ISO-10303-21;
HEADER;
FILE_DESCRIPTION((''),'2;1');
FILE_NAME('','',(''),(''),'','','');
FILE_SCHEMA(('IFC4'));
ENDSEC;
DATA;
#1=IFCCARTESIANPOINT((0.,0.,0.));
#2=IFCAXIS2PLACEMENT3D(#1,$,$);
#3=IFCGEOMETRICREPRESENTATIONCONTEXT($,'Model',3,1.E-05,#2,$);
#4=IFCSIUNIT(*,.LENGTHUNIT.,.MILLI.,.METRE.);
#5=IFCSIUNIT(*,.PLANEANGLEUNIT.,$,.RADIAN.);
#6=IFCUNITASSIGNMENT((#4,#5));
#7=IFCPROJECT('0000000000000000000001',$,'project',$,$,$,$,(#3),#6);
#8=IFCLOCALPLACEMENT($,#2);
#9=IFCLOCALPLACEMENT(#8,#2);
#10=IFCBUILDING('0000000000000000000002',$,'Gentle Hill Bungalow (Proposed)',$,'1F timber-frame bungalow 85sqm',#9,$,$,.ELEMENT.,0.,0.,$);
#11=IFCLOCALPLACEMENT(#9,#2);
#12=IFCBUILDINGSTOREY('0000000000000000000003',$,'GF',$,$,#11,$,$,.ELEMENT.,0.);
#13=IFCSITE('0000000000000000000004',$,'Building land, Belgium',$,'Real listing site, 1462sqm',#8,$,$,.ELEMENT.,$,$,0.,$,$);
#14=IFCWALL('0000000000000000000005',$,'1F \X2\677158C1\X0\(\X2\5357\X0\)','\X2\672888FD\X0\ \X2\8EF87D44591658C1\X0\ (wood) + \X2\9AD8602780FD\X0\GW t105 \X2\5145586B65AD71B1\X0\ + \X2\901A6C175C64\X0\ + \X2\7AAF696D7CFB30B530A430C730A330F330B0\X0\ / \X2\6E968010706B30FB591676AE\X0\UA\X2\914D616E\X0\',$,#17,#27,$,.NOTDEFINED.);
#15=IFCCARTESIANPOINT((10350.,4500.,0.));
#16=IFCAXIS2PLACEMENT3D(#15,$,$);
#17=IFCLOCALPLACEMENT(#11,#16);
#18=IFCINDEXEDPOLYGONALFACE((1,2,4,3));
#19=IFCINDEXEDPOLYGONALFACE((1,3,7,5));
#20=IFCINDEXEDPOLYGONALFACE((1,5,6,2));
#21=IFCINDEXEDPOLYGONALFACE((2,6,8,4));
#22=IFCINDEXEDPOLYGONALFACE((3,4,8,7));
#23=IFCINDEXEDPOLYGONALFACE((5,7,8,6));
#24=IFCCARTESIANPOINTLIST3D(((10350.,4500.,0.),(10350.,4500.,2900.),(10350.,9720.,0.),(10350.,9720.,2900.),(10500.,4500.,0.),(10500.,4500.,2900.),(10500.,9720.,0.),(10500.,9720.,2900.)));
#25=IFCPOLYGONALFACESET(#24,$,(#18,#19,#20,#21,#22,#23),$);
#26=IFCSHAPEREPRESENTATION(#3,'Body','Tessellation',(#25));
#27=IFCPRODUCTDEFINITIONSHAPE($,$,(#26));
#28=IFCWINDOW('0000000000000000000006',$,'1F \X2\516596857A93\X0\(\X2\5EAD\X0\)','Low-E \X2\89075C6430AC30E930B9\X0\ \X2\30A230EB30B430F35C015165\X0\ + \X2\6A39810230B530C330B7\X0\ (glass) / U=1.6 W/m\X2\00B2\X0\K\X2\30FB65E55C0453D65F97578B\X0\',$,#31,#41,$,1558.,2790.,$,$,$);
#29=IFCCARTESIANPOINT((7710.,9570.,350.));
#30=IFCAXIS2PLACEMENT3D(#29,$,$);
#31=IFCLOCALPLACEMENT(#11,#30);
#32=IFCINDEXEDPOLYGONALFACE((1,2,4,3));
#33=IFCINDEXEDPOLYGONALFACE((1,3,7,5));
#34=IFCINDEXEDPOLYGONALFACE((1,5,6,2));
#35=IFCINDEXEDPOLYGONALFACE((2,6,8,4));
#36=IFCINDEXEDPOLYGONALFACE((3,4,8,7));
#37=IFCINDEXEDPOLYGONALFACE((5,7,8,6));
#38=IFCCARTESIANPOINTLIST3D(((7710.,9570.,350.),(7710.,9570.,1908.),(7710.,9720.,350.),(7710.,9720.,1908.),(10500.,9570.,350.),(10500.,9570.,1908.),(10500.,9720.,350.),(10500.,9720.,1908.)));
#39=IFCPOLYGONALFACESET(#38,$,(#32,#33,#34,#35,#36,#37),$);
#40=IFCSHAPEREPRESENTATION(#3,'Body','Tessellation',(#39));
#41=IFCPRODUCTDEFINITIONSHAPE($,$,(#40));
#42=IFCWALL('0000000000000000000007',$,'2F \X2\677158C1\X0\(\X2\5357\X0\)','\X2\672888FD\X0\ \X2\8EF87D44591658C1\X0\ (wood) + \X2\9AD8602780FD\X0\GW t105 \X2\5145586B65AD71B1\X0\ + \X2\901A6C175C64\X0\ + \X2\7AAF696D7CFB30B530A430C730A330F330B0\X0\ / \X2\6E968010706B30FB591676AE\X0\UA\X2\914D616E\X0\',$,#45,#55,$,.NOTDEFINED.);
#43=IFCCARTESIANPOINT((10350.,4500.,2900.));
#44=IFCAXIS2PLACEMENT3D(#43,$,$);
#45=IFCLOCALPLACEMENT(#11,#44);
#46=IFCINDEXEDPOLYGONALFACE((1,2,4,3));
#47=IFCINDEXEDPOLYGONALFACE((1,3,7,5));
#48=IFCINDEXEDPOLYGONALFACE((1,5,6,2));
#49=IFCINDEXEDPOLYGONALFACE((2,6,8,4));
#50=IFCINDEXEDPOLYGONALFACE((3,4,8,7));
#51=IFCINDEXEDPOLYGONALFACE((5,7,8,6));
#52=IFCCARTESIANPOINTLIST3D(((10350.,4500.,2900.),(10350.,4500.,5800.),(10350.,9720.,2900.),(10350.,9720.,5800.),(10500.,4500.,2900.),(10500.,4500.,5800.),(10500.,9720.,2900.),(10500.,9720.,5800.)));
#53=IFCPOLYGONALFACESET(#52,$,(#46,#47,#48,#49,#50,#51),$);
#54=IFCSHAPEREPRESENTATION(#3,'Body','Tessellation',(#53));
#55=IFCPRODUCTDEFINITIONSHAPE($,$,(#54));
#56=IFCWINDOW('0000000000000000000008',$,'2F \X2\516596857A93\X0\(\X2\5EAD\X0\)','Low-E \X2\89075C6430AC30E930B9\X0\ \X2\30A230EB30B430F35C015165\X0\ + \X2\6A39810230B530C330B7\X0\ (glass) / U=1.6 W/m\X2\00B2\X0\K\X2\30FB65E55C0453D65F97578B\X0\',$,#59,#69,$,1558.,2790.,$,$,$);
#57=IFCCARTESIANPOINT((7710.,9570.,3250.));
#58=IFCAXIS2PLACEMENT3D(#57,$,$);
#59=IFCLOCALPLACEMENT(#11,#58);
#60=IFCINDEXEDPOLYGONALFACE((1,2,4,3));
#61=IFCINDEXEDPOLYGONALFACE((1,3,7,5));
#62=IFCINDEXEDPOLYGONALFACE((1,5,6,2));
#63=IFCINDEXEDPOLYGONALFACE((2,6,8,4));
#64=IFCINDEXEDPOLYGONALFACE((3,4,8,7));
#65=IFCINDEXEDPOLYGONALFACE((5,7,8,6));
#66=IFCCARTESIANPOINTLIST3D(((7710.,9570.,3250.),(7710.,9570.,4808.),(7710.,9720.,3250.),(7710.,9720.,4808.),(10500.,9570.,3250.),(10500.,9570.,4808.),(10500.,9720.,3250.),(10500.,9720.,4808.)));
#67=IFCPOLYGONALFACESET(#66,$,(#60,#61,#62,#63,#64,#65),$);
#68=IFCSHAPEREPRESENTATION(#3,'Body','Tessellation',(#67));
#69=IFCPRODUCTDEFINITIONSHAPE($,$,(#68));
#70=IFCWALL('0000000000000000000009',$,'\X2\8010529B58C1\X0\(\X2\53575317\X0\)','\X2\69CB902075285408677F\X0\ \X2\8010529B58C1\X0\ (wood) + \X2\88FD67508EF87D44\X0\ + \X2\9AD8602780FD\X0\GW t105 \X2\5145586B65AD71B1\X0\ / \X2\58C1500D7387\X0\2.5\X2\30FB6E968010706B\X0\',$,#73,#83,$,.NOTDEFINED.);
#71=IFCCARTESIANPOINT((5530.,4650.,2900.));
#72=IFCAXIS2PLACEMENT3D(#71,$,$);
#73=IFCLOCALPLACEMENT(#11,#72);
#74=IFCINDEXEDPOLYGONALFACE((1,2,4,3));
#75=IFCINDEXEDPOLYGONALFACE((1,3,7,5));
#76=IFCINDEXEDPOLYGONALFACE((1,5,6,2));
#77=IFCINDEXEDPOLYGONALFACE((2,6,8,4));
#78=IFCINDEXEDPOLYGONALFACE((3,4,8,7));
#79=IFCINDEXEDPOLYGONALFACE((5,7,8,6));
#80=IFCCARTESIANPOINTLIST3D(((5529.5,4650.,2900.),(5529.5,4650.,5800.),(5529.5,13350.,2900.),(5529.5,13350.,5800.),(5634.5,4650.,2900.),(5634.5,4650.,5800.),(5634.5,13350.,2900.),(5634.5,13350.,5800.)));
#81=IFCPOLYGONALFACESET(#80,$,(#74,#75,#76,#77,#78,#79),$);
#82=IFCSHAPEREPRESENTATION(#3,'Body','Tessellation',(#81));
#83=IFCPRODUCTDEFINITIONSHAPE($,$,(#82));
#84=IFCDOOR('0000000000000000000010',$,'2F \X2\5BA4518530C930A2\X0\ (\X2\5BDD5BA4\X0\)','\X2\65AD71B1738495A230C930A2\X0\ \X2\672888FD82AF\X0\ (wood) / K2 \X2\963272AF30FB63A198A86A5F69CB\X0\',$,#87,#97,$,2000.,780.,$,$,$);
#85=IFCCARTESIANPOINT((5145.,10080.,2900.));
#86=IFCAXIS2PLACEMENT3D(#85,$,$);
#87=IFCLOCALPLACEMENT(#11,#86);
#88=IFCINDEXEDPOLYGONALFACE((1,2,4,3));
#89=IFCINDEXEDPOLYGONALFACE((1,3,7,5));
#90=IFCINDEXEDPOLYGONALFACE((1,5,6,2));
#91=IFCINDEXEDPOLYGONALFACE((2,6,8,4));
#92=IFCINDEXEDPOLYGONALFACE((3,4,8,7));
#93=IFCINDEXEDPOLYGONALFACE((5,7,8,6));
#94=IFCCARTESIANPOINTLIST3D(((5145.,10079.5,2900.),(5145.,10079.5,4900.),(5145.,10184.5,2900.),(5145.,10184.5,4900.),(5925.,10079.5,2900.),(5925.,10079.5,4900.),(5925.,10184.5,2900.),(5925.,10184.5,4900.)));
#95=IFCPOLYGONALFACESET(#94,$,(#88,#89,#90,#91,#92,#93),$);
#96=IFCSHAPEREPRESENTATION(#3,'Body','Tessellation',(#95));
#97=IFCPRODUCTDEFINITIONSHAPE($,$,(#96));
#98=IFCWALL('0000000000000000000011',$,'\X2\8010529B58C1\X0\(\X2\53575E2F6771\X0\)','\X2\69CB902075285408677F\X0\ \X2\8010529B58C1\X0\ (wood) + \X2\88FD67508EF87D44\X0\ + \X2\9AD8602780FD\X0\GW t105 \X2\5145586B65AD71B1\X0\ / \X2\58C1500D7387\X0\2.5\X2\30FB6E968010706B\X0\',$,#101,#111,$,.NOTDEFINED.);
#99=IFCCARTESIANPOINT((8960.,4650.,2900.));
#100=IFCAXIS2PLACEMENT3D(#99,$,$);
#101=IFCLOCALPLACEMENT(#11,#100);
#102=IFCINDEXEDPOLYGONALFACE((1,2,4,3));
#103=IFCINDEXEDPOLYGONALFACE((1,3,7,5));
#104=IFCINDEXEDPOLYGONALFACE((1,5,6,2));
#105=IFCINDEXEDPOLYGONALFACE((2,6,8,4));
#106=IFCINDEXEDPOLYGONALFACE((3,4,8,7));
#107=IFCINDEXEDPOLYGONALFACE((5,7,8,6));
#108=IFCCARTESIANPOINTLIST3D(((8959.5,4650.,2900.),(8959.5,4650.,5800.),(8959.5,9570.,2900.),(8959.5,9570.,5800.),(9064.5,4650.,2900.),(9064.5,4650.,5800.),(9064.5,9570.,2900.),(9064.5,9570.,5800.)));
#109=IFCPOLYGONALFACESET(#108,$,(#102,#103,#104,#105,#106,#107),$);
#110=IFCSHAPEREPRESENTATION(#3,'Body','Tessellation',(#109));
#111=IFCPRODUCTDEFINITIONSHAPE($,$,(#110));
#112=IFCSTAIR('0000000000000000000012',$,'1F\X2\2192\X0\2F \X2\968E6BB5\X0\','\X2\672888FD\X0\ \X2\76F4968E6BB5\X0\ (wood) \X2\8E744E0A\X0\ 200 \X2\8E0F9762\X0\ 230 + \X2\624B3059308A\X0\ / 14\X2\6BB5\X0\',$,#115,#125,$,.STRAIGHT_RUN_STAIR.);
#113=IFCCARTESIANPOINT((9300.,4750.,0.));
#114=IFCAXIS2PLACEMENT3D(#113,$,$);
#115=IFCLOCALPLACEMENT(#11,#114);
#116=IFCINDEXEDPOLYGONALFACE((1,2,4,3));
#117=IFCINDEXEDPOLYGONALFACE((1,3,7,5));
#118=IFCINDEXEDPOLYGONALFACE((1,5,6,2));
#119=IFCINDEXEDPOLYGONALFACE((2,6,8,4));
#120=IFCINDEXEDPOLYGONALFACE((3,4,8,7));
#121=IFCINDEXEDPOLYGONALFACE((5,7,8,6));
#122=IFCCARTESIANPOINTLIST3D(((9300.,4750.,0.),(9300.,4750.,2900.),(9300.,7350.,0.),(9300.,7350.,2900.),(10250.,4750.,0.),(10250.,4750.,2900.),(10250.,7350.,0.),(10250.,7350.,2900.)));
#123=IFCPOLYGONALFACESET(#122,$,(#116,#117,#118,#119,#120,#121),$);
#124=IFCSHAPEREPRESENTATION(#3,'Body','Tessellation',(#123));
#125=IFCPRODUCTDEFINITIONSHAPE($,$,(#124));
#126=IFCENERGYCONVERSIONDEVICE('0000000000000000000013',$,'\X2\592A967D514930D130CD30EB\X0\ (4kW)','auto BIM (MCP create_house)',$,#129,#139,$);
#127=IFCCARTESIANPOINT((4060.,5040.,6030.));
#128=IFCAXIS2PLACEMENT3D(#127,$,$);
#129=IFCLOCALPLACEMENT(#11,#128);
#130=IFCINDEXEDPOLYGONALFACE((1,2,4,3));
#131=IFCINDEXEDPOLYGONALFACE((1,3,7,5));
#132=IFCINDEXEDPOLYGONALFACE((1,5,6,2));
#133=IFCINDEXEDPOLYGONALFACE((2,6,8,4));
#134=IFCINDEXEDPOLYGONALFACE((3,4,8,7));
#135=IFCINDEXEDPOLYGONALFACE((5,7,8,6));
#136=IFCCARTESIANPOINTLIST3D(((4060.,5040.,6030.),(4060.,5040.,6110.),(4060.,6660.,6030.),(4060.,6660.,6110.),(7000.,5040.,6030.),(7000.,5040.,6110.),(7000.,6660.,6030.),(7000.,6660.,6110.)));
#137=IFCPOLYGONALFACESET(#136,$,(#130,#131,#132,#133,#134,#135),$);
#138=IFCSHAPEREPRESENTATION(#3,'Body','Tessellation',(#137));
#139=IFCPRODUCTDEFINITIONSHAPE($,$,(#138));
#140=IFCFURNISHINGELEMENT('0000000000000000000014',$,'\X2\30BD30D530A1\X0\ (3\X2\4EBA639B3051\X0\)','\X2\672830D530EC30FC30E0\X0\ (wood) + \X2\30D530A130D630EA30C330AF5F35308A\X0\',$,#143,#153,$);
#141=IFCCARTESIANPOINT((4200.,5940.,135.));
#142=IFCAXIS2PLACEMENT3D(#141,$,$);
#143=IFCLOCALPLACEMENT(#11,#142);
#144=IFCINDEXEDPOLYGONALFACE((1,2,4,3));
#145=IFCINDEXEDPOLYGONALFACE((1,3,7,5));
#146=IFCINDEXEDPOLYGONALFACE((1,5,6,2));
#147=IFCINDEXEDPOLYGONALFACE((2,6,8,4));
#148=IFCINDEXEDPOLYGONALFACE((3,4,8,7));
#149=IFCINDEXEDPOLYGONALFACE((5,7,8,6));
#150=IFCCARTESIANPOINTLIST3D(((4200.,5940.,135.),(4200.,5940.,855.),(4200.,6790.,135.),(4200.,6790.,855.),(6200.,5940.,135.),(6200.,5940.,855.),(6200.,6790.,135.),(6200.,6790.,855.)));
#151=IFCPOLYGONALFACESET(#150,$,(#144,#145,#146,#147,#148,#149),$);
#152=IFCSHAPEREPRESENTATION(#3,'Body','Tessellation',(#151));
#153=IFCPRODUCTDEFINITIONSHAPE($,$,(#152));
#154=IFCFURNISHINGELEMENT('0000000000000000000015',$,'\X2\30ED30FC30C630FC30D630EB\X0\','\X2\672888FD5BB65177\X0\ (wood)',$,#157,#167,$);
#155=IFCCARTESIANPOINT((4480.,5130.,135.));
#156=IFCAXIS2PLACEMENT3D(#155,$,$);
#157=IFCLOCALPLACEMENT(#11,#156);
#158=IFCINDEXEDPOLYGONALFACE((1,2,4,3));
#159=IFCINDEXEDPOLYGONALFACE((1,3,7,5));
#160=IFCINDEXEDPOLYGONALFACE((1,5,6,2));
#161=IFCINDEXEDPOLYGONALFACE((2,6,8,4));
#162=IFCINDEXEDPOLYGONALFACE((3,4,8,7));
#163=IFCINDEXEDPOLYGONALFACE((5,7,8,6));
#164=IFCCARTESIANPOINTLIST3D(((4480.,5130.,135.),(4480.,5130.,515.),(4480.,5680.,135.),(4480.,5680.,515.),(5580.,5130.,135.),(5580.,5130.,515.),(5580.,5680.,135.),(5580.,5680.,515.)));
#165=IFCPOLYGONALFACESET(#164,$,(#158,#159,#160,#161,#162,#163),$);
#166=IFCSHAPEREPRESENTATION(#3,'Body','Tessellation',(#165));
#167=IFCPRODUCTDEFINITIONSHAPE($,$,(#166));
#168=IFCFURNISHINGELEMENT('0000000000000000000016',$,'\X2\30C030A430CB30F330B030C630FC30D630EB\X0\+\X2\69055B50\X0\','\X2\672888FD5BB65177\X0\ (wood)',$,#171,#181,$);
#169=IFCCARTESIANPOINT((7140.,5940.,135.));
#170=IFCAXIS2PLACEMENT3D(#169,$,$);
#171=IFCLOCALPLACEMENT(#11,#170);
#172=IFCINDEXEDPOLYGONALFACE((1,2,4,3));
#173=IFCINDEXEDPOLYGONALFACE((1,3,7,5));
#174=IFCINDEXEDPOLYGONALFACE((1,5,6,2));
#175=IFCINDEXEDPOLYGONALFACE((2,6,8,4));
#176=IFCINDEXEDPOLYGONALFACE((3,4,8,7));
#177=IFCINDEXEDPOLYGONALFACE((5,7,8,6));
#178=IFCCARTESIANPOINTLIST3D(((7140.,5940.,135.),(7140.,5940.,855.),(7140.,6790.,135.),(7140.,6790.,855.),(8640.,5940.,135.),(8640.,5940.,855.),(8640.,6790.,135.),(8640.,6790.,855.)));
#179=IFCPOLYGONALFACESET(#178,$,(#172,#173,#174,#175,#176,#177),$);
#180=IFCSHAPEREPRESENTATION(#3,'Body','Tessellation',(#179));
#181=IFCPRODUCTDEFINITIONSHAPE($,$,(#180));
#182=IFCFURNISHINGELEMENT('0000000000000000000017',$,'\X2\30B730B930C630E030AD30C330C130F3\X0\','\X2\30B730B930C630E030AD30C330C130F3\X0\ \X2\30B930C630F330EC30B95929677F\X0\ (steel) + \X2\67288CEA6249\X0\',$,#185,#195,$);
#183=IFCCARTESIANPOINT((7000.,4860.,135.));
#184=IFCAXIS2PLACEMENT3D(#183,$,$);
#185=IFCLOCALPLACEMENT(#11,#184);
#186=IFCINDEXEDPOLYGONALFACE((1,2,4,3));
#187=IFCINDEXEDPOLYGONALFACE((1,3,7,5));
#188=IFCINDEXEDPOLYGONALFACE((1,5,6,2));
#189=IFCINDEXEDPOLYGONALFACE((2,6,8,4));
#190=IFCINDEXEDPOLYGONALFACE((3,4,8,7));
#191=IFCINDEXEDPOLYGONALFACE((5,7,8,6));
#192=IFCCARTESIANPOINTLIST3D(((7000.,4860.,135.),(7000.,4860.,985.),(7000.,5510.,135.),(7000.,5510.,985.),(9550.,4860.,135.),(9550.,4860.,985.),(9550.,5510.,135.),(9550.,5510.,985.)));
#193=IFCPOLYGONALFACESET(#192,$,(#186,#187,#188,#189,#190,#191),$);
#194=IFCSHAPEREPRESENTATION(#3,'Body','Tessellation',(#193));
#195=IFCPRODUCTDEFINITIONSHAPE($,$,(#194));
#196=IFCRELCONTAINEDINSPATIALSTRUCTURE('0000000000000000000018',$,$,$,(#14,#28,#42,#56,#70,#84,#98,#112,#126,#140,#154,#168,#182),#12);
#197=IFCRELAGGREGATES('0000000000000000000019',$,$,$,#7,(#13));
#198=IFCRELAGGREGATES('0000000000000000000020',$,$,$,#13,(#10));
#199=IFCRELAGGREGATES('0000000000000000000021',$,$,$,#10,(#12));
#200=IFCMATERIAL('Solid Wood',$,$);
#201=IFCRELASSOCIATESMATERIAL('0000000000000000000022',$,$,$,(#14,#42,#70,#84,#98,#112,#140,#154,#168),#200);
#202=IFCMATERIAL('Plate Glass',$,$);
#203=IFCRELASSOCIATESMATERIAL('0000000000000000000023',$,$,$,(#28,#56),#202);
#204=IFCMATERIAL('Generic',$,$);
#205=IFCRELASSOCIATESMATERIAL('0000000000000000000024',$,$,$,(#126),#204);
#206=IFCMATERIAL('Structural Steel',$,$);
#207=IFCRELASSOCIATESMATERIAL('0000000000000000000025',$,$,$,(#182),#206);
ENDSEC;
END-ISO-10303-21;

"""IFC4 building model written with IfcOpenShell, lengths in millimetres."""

from ifc_helpers import new_model, si_unit, frame, frame_2d, origin, place, context, project, spatial, rectangle, extrude, material, element, fill, save


model = new_model("IFC4")

# Units and contexts
model_context = context("Model", 3, precision=1e-05, world=origin())
ifc_project = project(units=[si_unit("LENGTHUNIT", "METRE", prefix="MILLI"), si_unit("PLANEANGLEUNIT", "RADIAN")], contexts=[model_context])

# Site, building, storey
site_placement = place(None, origin())
site = spatial("IfcSite", under=ifc_project, at=site_placement, Name="Building land, Belgium", ObjectType="Real listing site, 1462sqm", CompositionType="ELEMENT", RefElevation=0.0)
building_placement = place(site_placement, origin())
building = spatial("IfcBuilding", under=site, at=building_placement, Name="Gentle Hill Bungalow (Proposed)", ObjectType="1F timber-frame bungalow 85sqm", CompositionType="ELEMENT", ElevationOfRefHeight=0.0, ElevationOfTerrain=0.0)
storey_placement = place(building_placement, origin())
storey = spatial("IfcBuildingStorey", under=building, at=storey_placement, Name="GF", CompositionType="ELEMENT", Elevation=0.0)

# Wall, opening, window
ifc_material_1 = material(Name="Solid Wood")
wall_1_placement = place(storey_placement, frame((10350.0, 4500.0, 0.0)))
wall_1 = element("IfcWall", 1, at=wall_1_placement, inside=storey, material=ifc_material_1, Name="1F 東壁(南)", Description="木製 軸組外壁 (wood) + 高性能GW t105 充填断熱 + 通気層 + 窯業系サイディング / 準耐火・外皮UA配慮", PredefinedType="NOTDEFINED", context=model_context, shape_type="SweptSolid", body=[
    extrude(rectangle(XDim=150.0, YDim=5220.0, at=frame_2d((75.0, 2610.0))), frame((10350.0, 4500.0, 0.0)), (0.0, 0.0, 1.0), 2900.0),
])
opening_1_placement = place(storey_placement, frame((7710.0, 9570.0, 350.0)))
opening_1 = element("IfcOpeningElement", 2, at=opening_1_placement, cuts=wall_1, PredefinedType="NOTDEFINED", context=model_context, shape_type="SweptSolid", body=[
    extrude(rectangle(XDim=2790.0, YDim=150.0, at=frame_2d((1395.0, 75.0))), frame((7710.0, 9570.0, 350.0)), (0.0, 0.0, 1.0), 1558.0),
])
ifc_material_2 = material(Name="Plate Glass")
window_1_placement = place(storey_placement, frame((7710.0, 9570.0, 350.0)))
window_1 = element("IfcWindow", 3, at=window_1_placement, inside=storey, material=ifc_material_2, Name="1F 入隅窓(庭)", Description="Low-E 複層ガラス アルゴン封入 + 樹脂サッシ (glass) / U=1.6 W/m²K・日射取得型", OverallHeight=1558.0, OverallWidth=2790.0, context=model_context, shape_type="SweptSolid", body=[
    extrude(rectangle(XDim=2790.0, YDim=150.0, at=frame_2d((1395.0, 75.0))), frame((7710.0, 9570.0, 350.0)), (0.0, 0.0, 1.0), 1558.0),
])
fill(opening_1, window_1)

# Wall, opening, window
wall_2_placement = place(storey_placement, frame((10350.0, 4500.0, 2900.0)))
wall_2 = element("IfcWall", 4, at=wall_2_placement, inside=storey, material=ifc_material_1, Name="2F 東壁(南)", Description="木製 軸組外壁 (wood) + 高性能GW t105 充填断熱 + 通気層 + 窯業系サイディング / 準耐火・外皮UA配慮", PredefinedType="NOTDEFINED", context=model_context, shape_type="SweptSolid", body=[
    extrude(rectangle(XDim=150.0, YDim=5220.0, at=frame_2d((75.0, 2610.0))), frame((10350.0, 4500.0, 2900.0)), (0.0, 0.0, 1.0), 2900.0),
])
opening_2_placement = place(storey_placement, frame((7710.0, 9570.0, 3250.0)))
opening_2 = element("IfcOpeningElement", 5, at=opening_2_placement, cuts=wall_2, PredefinedType="NOTDEFINED", context=model_context, shape_type="SweptSolid", body=[
    extrude(rectangle(XDim=2790.0, YDim=150.0, at=frame_2d((1395.0, 75.0))), frame((7710.0, 9570.0, 3250.0)), (0.0, 0.0, 1.0), 1558.0),
])
window_2_placement = place(storey_placement, frame((7710.0, 9570.0, 3250.0)))
window_2 = element("IfcWindow", 6, at=window_2_placement, inside=storey, material=ifc_material_2, Name="2F 入隅窓(庭)", Description="Low-E 複層ガラス アルゴン封入 + 樹脂サッシ (glass) / U=1.6 W/m²K・日射取得型", OverallHeight=1558.0, OverallWidth=2790.0, context=model_context, shape_type="SweptSolid", body=[
    extrude(rectangle(XDim=2790.0, YDim=150.0, at=frame_2d((1395.0, 75.0))), frame((7710.0, 9570.0, 3250.0)), (0.0, 0.0, 1.0), 1558.0),
])
fill(opening_2, window_2)

# Wall, opening, door
wall_3_placement = place(storey_placement, frame((5530.0, 4650.0, 2900.0)))
wall_3 = element("IfcWall", 7, at=wall_3_placement, inside=storey, material=ifc_material_1, Name="耐力壁(南北)", Description="構造用合板 耐力壁 (wood) + 製材軸組 + 高性能GW t105 充填断熱 / 壁倍率2.5・準耐火", PredefinedType="NOTDEFINED", context=model_context, shape_type="SweptSolid", body=[
    extrude(rectangle(XDim=105.0, YDim=8700.0, at=frame_2d((52.0, 4350.0))), frame((5530.0, 4650.0, 2900.0)), (0.0, 0.0, 1.0), 2900.0),
])
opening_3_placement = place(storey_placement, frame((5145.0, 10080.0, 2900.0)))
opening_3 = element("IfcOpeningElement", 8, at=opening_3_placement, cuts=wall_3, PredefinedType="NOTDEFINED", context=model_context, shape_type="SweptSolid", body=[
    extrude(rectangle(XDim=780.0, YDim=105.0, at=frame_2d((390.0, 52.0))), frame((5145.0, 10080.0, 2900.0)), (0.0, 0.0, 1.0), 2000.0),
])
door_1_placement = place(storey_placement, frame((5145.0, 10080.0, 2900.0)))
door_1 = element("IfcDoor", 9, at=door_1_placement, inside=storey, material=ifc_material_1, Name="2F 室内ドア (寝室)", Description="断熱玄関ドア 木製芯 (wood) / K2 防犯・採風機構", OverallHeight=2000.0, OverallWidth=780.0, context=model_context, shape_type="SweptSolid", body=[
    extrude(rectangle(XDim=780.0, YDim=105.0, at=frame_2d((390.0, 52.0))), frame((5145.0, 10080.0, 2900.0)), (0.0, 0.0, 1.0), 2000.0),
])
fill(opening_3, door_1)

# Wall
wall_4_placement = place(storey_placement, frame((8960.0, 4650.0, 2900.0)))
element("IfcWall", 10, at=wall_4_placement, inside=storey, material=ifc_material_1, Name="耐力壁(南帯東)", Description="構造用合板 耐力壁 (wood) + 製材軸組 + 高性能GW t105 充填断熱 / 壁倍率2.5・準耐火", PredefinedType="NOTDEFINED", context=model_context, shape_type="SweptSolid", body=[
    extrude(rectangle(XDim=105.0, YDim=4920.0, at=frame_2d((52.0, 2460.0))), frame((8960.0, 4650.0, 2900.0)), (0.0, 0.0, 1.0), 2900.0),
])

# Stair
stair_placement = place(storey_placement, frame((9300.0, 4750.0, 0.0)))
element("IfcStair", 11, at=stair_placement, inside=storey, material=ifc_material_1, Name="1F→2F 階段", Description="木製 直階段 (wood) 蹴上 200 踏面 230 + 手すり / 14段", PredefinedType="STRAIGHT_RUN_STAIR", context=model_context, shape_type="SweptSolid", body=[
    extrude(rectangle(XDim=950.0, YDim=2600.0, at=frame_2d((475.0, 1300.0))), frame((9300.0, 4750.0, 0.0)), (0.0, 0.0, 1.0), 2900.0),
])

# Energy conversion device
ifc_material_3 = material(Name="Generic")
energy_conversion_device_placement = place(storey_placement, frame((4060.0, 5040.0, 6030.0)))
element("IfcEnergyConversionDevice", 12, at=energy_conversion_device_placement, inside=storey, material=ifc_material_3, Name="太陽光パネル (4kW)", Description="auto BIM (MCP create_house)", context=model_context, shape_type="SweptSolid", body=[
    extrude(rectangle(XDim=2940.0, YDim=1620.0, at=frame_2d((1470.0, 810.0))), frame((4060.0, 5040.0, 6030.0)), (0.0, 0.0, 1.0), 80.0),
])

# Furnishing elements
furnishing_1_placement = place(storey_placement, frame((4200.0, 5940.0, 135.0)))
element("IfcFurnishingElement", 13, at=furnishing_1_placement, inside=storey, material=ifc_material_1, Name="ソファ (3人掛け)", Description="木フレーム (wood) + ファブリック張り", context=model_context, shape_type="SweptSolid", body=[
    extrude(rectangle(XDim=2000.0, YDim=850.0, at=frame_2d((1000.0, 425.0))), frame((4200.0, 5940.0, 135.0)), (0.0, 0.0, 1.0), 720.0),
])
furnishing_2_placement = place(storey_placement, frame((4480.0, 5130.0, 135.0)))
element("IfcFurnishingElement", 14, at=furnishing_2_placement, inside=storey, material=ifc_material_1, Name="ローテーブル", Description="木製家具 (wood)", context=model_context, shape_type="SweptSolid", body=[
    extrude(rectangle(XDim=1100.0, YDim=550.0, at=frame_2d((550.0, 275.0))), frame((4480.0, 5130.0, 135.0)), (0.0, 0.0, 1.0), 380.0),
])
furnishing_3_placement = place(storey_placement, frame((7140.0, 5940.0, 135.0)))
element("IfcFurnishingElement", 15, at=furnishing_3_placement, inside=storey, material=ifc_material_1, Name="ダイニングテーブル+椅子", Description="木製家具 (wood)", context=model_context, shape_type="SweptSolid", body=[
    extrude(rectangle(XDim=1500.0, YDim=850.0, at=frame_2d((750.0, 425.0))), frame((7140.0, 5940.0, 135.0)), (0.0, 0.0, 1.0), 720.0),
])
ifc_material_4 = material(Name="Structural Steel")
furnishing_4_placement = place(storey_placement, frame((7000.0, 4860.0, 135.0)))
element("IfcFurnishingElement", 16, at=furnishing_4_placement, inside=storey, material=ifc_material_4, Name="システムキッチン", Description="システムキッチン ステンレス天板 (steel) + 木質扉", context=model_context, shape_type="SweptSolid", body=[
    extrude(rectangle(XDim=2550.0, YDim=650.0, at=frame_2d((1275.0, 325.0))), frame((7000.0, 4860.0, 135.0)), (0.0, 0.0, 1.0), 850.0),
])

save(model, "model.ifc")
